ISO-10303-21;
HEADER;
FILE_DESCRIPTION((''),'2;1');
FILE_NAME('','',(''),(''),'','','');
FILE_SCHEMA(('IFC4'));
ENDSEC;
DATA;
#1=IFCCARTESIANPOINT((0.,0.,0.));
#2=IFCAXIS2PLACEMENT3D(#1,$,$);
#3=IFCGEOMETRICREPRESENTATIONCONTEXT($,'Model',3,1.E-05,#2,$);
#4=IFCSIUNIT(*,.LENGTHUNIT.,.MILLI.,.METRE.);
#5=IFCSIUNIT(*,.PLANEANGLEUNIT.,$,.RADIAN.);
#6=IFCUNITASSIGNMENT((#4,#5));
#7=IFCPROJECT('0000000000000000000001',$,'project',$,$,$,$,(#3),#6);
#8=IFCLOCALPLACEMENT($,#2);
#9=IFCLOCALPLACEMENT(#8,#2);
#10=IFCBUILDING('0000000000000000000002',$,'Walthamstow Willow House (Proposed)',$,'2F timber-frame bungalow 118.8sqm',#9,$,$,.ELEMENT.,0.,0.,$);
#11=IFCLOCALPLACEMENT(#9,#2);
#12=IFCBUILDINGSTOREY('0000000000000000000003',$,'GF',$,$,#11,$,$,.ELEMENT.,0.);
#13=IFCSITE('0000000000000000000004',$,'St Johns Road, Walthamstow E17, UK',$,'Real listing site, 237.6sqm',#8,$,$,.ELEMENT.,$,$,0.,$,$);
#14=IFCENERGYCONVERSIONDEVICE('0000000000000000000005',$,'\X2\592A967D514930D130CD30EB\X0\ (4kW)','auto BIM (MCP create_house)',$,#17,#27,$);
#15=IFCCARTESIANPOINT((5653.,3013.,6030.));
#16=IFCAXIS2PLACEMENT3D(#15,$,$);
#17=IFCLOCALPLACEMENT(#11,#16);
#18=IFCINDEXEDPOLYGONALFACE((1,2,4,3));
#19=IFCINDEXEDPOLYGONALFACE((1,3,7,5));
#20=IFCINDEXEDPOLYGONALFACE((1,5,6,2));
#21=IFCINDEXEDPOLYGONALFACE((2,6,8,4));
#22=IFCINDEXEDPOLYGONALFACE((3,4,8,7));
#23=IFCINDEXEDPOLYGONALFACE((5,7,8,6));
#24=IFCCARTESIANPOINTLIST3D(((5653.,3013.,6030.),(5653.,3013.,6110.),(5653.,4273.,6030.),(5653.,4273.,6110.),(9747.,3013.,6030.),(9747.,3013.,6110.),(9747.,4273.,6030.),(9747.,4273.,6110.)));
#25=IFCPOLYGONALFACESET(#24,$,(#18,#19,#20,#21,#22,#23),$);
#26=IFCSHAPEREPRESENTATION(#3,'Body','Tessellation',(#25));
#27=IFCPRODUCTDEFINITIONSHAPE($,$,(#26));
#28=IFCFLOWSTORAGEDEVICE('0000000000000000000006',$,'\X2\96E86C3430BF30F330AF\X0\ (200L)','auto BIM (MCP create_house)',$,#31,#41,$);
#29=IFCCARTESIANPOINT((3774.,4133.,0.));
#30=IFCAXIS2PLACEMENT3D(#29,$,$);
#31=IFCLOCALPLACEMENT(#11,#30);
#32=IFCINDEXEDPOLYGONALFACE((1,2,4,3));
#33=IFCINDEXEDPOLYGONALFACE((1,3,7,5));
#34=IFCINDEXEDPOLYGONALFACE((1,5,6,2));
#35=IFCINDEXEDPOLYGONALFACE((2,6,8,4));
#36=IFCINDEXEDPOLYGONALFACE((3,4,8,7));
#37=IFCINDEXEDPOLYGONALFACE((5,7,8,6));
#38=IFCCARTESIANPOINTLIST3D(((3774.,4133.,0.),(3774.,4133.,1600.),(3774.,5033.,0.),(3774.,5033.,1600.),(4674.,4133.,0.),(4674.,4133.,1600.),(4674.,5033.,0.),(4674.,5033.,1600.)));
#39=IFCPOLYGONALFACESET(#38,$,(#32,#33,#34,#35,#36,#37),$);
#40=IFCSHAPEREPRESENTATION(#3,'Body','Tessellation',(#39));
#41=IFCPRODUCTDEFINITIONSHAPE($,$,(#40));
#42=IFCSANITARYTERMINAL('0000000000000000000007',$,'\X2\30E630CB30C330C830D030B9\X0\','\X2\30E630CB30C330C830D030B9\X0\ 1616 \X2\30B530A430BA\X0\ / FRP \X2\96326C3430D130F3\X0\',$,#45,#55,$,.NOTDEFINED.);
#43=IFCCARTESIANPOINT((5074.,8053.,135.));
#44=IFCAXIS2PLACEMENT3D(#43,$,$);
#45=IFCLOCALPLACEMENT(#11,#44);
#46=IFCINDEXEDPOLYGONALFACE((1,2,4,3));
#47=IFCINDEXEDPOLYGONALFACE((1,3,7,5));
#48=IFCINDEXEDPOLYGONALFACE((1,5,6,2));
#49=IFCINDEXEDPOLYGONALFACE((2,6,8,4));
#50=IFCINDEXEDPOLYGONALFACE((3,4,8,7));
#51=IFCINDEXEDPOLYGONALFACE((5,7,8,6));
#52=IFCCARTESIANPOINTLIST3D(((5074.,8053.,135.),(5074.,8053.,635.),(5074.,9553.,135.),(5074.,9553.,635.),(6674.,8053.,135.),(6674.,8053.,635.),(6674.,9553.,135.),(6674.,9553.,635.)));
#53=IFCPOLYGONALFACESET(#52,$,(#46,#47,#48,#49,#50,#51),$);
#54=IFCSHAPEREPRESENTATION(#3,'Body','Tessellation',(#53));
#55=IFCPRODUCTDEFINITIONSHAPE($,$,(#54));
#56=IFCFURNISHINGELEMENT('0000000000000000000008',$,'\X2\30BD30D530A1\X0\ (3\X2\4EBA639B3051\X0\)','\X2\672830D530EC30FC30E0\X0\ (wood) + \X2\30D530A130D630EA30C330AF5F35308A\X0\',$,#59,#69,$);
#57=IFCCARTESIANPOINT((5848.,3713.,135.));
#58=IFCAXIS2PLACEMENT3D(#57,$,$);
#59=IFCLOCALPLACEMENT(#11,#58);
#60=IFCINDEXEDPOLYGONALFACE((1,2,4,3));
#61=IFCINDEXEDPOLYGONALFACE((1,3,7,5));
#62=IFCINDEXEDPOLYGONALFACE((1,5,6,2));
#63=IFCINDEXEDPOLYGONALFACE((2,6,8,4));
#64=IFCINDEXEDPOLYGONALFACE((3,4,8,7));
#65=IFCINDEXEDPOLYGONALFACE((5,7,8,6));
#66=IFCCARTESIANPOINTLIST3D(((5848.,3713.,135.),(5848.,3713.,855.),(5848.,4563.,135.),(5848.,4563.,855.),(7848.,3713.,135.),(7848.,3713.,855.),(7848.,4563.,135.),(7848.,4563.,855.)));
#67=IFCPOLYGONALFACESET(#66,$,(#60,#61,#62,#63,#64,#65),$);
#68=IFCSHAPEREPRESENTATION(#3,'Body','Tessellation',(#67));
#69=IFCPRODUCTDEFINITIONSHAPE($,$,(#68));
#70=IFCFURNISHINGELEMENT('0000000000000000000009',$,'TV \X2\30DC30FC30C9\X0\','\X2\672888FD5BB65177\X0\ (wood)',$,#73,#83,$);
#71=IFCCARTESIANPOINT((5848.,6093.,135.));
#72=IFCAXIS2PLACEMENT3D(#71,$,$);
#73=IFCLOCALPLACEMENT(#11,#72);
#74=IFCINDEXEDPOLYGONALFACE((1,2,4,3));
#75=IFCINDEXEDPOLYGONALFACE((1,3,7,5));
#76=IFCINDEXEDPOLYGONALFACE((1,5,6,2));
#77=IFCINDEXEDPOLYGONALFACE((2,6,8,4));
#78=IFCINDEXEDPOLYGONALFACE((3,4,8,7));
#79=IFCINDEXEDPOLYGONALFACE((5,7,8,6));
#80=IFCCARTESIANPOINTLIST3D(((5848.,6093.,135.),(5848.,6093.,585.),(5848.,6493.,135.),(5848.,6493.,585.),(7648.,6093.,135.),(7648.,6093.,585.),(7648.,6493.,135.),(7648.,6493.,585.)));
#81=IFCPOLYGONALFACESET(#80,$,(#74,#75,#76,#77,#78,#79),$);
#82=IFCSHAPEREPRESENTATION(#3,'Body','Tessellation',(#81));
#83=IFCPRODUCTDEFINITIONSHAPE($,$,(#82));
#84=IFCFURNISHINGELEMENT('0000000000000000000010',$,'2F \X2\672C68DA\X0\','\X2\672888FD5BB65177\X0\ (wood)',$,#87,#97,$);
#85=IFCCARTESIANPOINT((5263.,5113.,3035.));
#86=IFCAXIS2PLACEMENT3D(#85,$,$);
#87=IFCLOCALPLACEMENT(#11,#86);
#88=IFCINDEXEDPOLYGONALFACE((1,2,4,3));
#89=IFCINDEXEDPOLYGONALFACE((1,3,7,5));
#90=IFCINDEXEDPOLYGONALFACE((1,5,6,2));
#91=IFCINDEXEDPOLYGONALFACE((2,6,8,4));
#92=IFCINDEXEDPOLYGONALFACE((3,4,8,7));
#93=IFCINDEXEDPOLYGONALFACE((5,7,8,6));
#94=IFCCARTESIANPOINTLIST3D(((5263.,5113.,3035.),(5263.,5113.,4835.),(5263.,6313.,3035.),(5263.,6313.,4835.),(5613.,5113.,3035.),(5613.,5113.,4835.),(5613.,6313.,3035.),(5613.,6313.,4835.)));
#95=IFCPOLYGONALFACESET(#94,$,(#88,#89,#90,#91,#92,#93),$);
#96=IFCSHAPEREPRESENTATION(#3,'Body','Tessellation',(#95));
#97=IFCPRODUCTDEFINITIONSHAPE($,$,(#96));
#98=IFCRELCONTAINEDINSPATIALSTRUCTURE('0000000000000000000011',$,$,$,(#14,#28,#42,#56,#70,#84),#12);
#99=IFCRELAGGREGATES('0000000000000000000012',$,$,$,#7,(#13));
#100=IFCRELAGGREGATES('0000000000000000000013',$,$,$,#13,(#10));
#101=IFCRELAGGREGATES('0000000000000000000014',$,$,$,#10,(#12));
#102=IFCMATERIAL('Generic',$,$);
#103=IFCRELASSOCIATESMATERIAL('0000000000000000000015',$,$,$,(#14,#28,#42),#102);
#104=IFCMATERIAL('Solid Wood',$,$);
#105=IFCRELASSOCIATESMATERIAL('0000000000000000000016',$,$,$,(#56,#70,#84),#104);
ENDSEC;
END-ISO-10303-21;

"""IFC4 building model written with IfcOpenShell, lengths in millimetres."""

from ifc_helpers import new_model, si_unit, frame, frame_2d, origin, place, context, project, spatial, rectangle, extrude, material, element, save


model = new_model("IFC4")

# Units and contexts
model_context = context("Model", 3, precision=1e-05, world=origin())
ifc_project = project(units=[si_unit("LENGTHUNIT", "METRE", prefix="MILLI"), si_unit("PLANEANGLEUNIT", "RADIAN")], contexts=[model_context])

# Site, building, storey
site_placement = place(None, origin())
site = spatial("IfcSite", under=ifc_project, at=site_placement, Name="St Johns Road, Walthamstow E17, UK", ObjectType="Real listing site, 237.6sqm", CompositionType="ELEMENT", RefElevation=0.0)
building_placement = place(site_placement, origin())
building = spatial("IfcBuilding", under=site, at=building_placement, Name="Walthamstow Willow House (Proposed)", ObjectType="2F timber-frame bungalow 118.8sqm", CompositionType="ELEMENT", ElevationOfRefHeight=0.0, ElevationOfTerrain=0.0)
storey_placement = place(building_placement, origin())
storey = spatial("IfcBuildingStorey", under=building, at=storey_placement, Name="GF", CompositionType="ELEMENT", Elevation=0.0)

# Shared definitions
ifc_material_1 = material(Name="Solid Wood")

# Energy conversion device
ifc_material_2 = material(Name="Generic")
energy_conversion_device_placement = place(storey_placement, frame((5653.0, 3013.0, 6030.0)))
element("IfcEnergyConversionDevice", 1, at=energy_conversion_device_placement, inside=storey, material=ifc_material_2, Name="太陽光パネル (4kW)", Description="auto BIM (MCP create_house)", context=model_context, shape_type="SweptSolid", body=[
    extrude(rectangle(XDim=4094.0, YDim=1260.0, at=frame_2d((2047.0, 630.0))), frame((5653.0, 3013.0, 6030.0)), (0.0, 0.0, 1.0), 80.0),
])

# Flow storage device
flow_storage_device_placement = place(storey_placement, frame((3774.0, 4133.0, 0.0)))
element("IfcFlowStorageDevice", 2, at=flow_storage_device_placement, inside=storey, material=ifc_material_2, Name="雨水タンク (200L)", Description="auto BIM (MCP create_house)", context=model_context, shape_type="SweptSolid", body=[
    extrude(rectangle(XDim=900.0, YDim=900.0, at=frame_2d((450.0, 450.0))), frame((3774.0, 4133.0, 0.0)), (0.0, 0.0, 1.0), 1600.0),
])

# Sanitary terminal
sanitary_terminal_placement = place(storey_placement, frame((5074.0, 8053.0, 135.0)))
element("IfcSanitaryTerminal", 3, at=sanitary_terminal_placement, inside=storey, material=ifc_material_2, Name="ユニットバス", Description="ユニットバス 1616 サイズ / FRP 防水パン", PredefinedType="NOTDEFINED", context=model_context, shape_type="SweptSolid", body=[
    extrude(rectangle(XDim=1600.0, YDim=1500.0, at=frame_2d((800.0, 750.0))), frame((5074.0, 8053.0, 135.0)), (0.0, 0.0, 1.0), 500.0),
])

# Furnishing elements
furnishing_1_placement = place(storey_placement, frame((5848.0, 3713.0, 135.0)))
element("IfcFurnishingElement", 4, at=furnishing_1_placement, inside=storey, material=ifc_material_1, Name="ソファ (3人掛け)", Description="木フレーム (wood) + ファブリック張り", context=model_context, shape_type="SweptSolid", body=[
    extrude(rectangle(XDim=2000.0, YDim=850.0, at=frame_2d((1000.0, 425.0))), frame((5848.0, 3713.0, 135.0)), (0.0, 0.0, 1.0), 720.0),
])
furnishing_2_placement = place(storey_placement, frame((5848.0, 6093.0, 135.0)))
element("IfcFurnishingElement", 5, at=furnishing_2_placement, inside=storey, material=ifc_material_1, Name="TV ボード", Description="木製家具 (wood)", context=model_context, shape_type="SweptSolid", body=[
    extrude(rectangle(XDim=1800.0, YDim=400.0, at=frame_2d((900.0, 200.0))), frame((5848.0, 6093.0, 135.0)), (0.0, 0.0, 1.0), 450.0),
])
furnishing_3_placement = place(storey_placement, frame((5263.0, 5113.0, 3035.0)))
element("IfcFurnishingElement", 6, at=furnishing_3_placement, inside=storey, material=ifc_material_1, Name="2F 本棚", Description="木製家具 (wood)", context=model_context, shape_type="SweptSolid", body=[
    extrude(rectangle(XDim=350.0, YDim=1200.0, at=frame_2d((175.0, 600.0))), frame((5263.0, 5113.0, 3035.0)), (0.0, 0.0, 1.0), 1800.0),
])

save(model, "model.ifc")
